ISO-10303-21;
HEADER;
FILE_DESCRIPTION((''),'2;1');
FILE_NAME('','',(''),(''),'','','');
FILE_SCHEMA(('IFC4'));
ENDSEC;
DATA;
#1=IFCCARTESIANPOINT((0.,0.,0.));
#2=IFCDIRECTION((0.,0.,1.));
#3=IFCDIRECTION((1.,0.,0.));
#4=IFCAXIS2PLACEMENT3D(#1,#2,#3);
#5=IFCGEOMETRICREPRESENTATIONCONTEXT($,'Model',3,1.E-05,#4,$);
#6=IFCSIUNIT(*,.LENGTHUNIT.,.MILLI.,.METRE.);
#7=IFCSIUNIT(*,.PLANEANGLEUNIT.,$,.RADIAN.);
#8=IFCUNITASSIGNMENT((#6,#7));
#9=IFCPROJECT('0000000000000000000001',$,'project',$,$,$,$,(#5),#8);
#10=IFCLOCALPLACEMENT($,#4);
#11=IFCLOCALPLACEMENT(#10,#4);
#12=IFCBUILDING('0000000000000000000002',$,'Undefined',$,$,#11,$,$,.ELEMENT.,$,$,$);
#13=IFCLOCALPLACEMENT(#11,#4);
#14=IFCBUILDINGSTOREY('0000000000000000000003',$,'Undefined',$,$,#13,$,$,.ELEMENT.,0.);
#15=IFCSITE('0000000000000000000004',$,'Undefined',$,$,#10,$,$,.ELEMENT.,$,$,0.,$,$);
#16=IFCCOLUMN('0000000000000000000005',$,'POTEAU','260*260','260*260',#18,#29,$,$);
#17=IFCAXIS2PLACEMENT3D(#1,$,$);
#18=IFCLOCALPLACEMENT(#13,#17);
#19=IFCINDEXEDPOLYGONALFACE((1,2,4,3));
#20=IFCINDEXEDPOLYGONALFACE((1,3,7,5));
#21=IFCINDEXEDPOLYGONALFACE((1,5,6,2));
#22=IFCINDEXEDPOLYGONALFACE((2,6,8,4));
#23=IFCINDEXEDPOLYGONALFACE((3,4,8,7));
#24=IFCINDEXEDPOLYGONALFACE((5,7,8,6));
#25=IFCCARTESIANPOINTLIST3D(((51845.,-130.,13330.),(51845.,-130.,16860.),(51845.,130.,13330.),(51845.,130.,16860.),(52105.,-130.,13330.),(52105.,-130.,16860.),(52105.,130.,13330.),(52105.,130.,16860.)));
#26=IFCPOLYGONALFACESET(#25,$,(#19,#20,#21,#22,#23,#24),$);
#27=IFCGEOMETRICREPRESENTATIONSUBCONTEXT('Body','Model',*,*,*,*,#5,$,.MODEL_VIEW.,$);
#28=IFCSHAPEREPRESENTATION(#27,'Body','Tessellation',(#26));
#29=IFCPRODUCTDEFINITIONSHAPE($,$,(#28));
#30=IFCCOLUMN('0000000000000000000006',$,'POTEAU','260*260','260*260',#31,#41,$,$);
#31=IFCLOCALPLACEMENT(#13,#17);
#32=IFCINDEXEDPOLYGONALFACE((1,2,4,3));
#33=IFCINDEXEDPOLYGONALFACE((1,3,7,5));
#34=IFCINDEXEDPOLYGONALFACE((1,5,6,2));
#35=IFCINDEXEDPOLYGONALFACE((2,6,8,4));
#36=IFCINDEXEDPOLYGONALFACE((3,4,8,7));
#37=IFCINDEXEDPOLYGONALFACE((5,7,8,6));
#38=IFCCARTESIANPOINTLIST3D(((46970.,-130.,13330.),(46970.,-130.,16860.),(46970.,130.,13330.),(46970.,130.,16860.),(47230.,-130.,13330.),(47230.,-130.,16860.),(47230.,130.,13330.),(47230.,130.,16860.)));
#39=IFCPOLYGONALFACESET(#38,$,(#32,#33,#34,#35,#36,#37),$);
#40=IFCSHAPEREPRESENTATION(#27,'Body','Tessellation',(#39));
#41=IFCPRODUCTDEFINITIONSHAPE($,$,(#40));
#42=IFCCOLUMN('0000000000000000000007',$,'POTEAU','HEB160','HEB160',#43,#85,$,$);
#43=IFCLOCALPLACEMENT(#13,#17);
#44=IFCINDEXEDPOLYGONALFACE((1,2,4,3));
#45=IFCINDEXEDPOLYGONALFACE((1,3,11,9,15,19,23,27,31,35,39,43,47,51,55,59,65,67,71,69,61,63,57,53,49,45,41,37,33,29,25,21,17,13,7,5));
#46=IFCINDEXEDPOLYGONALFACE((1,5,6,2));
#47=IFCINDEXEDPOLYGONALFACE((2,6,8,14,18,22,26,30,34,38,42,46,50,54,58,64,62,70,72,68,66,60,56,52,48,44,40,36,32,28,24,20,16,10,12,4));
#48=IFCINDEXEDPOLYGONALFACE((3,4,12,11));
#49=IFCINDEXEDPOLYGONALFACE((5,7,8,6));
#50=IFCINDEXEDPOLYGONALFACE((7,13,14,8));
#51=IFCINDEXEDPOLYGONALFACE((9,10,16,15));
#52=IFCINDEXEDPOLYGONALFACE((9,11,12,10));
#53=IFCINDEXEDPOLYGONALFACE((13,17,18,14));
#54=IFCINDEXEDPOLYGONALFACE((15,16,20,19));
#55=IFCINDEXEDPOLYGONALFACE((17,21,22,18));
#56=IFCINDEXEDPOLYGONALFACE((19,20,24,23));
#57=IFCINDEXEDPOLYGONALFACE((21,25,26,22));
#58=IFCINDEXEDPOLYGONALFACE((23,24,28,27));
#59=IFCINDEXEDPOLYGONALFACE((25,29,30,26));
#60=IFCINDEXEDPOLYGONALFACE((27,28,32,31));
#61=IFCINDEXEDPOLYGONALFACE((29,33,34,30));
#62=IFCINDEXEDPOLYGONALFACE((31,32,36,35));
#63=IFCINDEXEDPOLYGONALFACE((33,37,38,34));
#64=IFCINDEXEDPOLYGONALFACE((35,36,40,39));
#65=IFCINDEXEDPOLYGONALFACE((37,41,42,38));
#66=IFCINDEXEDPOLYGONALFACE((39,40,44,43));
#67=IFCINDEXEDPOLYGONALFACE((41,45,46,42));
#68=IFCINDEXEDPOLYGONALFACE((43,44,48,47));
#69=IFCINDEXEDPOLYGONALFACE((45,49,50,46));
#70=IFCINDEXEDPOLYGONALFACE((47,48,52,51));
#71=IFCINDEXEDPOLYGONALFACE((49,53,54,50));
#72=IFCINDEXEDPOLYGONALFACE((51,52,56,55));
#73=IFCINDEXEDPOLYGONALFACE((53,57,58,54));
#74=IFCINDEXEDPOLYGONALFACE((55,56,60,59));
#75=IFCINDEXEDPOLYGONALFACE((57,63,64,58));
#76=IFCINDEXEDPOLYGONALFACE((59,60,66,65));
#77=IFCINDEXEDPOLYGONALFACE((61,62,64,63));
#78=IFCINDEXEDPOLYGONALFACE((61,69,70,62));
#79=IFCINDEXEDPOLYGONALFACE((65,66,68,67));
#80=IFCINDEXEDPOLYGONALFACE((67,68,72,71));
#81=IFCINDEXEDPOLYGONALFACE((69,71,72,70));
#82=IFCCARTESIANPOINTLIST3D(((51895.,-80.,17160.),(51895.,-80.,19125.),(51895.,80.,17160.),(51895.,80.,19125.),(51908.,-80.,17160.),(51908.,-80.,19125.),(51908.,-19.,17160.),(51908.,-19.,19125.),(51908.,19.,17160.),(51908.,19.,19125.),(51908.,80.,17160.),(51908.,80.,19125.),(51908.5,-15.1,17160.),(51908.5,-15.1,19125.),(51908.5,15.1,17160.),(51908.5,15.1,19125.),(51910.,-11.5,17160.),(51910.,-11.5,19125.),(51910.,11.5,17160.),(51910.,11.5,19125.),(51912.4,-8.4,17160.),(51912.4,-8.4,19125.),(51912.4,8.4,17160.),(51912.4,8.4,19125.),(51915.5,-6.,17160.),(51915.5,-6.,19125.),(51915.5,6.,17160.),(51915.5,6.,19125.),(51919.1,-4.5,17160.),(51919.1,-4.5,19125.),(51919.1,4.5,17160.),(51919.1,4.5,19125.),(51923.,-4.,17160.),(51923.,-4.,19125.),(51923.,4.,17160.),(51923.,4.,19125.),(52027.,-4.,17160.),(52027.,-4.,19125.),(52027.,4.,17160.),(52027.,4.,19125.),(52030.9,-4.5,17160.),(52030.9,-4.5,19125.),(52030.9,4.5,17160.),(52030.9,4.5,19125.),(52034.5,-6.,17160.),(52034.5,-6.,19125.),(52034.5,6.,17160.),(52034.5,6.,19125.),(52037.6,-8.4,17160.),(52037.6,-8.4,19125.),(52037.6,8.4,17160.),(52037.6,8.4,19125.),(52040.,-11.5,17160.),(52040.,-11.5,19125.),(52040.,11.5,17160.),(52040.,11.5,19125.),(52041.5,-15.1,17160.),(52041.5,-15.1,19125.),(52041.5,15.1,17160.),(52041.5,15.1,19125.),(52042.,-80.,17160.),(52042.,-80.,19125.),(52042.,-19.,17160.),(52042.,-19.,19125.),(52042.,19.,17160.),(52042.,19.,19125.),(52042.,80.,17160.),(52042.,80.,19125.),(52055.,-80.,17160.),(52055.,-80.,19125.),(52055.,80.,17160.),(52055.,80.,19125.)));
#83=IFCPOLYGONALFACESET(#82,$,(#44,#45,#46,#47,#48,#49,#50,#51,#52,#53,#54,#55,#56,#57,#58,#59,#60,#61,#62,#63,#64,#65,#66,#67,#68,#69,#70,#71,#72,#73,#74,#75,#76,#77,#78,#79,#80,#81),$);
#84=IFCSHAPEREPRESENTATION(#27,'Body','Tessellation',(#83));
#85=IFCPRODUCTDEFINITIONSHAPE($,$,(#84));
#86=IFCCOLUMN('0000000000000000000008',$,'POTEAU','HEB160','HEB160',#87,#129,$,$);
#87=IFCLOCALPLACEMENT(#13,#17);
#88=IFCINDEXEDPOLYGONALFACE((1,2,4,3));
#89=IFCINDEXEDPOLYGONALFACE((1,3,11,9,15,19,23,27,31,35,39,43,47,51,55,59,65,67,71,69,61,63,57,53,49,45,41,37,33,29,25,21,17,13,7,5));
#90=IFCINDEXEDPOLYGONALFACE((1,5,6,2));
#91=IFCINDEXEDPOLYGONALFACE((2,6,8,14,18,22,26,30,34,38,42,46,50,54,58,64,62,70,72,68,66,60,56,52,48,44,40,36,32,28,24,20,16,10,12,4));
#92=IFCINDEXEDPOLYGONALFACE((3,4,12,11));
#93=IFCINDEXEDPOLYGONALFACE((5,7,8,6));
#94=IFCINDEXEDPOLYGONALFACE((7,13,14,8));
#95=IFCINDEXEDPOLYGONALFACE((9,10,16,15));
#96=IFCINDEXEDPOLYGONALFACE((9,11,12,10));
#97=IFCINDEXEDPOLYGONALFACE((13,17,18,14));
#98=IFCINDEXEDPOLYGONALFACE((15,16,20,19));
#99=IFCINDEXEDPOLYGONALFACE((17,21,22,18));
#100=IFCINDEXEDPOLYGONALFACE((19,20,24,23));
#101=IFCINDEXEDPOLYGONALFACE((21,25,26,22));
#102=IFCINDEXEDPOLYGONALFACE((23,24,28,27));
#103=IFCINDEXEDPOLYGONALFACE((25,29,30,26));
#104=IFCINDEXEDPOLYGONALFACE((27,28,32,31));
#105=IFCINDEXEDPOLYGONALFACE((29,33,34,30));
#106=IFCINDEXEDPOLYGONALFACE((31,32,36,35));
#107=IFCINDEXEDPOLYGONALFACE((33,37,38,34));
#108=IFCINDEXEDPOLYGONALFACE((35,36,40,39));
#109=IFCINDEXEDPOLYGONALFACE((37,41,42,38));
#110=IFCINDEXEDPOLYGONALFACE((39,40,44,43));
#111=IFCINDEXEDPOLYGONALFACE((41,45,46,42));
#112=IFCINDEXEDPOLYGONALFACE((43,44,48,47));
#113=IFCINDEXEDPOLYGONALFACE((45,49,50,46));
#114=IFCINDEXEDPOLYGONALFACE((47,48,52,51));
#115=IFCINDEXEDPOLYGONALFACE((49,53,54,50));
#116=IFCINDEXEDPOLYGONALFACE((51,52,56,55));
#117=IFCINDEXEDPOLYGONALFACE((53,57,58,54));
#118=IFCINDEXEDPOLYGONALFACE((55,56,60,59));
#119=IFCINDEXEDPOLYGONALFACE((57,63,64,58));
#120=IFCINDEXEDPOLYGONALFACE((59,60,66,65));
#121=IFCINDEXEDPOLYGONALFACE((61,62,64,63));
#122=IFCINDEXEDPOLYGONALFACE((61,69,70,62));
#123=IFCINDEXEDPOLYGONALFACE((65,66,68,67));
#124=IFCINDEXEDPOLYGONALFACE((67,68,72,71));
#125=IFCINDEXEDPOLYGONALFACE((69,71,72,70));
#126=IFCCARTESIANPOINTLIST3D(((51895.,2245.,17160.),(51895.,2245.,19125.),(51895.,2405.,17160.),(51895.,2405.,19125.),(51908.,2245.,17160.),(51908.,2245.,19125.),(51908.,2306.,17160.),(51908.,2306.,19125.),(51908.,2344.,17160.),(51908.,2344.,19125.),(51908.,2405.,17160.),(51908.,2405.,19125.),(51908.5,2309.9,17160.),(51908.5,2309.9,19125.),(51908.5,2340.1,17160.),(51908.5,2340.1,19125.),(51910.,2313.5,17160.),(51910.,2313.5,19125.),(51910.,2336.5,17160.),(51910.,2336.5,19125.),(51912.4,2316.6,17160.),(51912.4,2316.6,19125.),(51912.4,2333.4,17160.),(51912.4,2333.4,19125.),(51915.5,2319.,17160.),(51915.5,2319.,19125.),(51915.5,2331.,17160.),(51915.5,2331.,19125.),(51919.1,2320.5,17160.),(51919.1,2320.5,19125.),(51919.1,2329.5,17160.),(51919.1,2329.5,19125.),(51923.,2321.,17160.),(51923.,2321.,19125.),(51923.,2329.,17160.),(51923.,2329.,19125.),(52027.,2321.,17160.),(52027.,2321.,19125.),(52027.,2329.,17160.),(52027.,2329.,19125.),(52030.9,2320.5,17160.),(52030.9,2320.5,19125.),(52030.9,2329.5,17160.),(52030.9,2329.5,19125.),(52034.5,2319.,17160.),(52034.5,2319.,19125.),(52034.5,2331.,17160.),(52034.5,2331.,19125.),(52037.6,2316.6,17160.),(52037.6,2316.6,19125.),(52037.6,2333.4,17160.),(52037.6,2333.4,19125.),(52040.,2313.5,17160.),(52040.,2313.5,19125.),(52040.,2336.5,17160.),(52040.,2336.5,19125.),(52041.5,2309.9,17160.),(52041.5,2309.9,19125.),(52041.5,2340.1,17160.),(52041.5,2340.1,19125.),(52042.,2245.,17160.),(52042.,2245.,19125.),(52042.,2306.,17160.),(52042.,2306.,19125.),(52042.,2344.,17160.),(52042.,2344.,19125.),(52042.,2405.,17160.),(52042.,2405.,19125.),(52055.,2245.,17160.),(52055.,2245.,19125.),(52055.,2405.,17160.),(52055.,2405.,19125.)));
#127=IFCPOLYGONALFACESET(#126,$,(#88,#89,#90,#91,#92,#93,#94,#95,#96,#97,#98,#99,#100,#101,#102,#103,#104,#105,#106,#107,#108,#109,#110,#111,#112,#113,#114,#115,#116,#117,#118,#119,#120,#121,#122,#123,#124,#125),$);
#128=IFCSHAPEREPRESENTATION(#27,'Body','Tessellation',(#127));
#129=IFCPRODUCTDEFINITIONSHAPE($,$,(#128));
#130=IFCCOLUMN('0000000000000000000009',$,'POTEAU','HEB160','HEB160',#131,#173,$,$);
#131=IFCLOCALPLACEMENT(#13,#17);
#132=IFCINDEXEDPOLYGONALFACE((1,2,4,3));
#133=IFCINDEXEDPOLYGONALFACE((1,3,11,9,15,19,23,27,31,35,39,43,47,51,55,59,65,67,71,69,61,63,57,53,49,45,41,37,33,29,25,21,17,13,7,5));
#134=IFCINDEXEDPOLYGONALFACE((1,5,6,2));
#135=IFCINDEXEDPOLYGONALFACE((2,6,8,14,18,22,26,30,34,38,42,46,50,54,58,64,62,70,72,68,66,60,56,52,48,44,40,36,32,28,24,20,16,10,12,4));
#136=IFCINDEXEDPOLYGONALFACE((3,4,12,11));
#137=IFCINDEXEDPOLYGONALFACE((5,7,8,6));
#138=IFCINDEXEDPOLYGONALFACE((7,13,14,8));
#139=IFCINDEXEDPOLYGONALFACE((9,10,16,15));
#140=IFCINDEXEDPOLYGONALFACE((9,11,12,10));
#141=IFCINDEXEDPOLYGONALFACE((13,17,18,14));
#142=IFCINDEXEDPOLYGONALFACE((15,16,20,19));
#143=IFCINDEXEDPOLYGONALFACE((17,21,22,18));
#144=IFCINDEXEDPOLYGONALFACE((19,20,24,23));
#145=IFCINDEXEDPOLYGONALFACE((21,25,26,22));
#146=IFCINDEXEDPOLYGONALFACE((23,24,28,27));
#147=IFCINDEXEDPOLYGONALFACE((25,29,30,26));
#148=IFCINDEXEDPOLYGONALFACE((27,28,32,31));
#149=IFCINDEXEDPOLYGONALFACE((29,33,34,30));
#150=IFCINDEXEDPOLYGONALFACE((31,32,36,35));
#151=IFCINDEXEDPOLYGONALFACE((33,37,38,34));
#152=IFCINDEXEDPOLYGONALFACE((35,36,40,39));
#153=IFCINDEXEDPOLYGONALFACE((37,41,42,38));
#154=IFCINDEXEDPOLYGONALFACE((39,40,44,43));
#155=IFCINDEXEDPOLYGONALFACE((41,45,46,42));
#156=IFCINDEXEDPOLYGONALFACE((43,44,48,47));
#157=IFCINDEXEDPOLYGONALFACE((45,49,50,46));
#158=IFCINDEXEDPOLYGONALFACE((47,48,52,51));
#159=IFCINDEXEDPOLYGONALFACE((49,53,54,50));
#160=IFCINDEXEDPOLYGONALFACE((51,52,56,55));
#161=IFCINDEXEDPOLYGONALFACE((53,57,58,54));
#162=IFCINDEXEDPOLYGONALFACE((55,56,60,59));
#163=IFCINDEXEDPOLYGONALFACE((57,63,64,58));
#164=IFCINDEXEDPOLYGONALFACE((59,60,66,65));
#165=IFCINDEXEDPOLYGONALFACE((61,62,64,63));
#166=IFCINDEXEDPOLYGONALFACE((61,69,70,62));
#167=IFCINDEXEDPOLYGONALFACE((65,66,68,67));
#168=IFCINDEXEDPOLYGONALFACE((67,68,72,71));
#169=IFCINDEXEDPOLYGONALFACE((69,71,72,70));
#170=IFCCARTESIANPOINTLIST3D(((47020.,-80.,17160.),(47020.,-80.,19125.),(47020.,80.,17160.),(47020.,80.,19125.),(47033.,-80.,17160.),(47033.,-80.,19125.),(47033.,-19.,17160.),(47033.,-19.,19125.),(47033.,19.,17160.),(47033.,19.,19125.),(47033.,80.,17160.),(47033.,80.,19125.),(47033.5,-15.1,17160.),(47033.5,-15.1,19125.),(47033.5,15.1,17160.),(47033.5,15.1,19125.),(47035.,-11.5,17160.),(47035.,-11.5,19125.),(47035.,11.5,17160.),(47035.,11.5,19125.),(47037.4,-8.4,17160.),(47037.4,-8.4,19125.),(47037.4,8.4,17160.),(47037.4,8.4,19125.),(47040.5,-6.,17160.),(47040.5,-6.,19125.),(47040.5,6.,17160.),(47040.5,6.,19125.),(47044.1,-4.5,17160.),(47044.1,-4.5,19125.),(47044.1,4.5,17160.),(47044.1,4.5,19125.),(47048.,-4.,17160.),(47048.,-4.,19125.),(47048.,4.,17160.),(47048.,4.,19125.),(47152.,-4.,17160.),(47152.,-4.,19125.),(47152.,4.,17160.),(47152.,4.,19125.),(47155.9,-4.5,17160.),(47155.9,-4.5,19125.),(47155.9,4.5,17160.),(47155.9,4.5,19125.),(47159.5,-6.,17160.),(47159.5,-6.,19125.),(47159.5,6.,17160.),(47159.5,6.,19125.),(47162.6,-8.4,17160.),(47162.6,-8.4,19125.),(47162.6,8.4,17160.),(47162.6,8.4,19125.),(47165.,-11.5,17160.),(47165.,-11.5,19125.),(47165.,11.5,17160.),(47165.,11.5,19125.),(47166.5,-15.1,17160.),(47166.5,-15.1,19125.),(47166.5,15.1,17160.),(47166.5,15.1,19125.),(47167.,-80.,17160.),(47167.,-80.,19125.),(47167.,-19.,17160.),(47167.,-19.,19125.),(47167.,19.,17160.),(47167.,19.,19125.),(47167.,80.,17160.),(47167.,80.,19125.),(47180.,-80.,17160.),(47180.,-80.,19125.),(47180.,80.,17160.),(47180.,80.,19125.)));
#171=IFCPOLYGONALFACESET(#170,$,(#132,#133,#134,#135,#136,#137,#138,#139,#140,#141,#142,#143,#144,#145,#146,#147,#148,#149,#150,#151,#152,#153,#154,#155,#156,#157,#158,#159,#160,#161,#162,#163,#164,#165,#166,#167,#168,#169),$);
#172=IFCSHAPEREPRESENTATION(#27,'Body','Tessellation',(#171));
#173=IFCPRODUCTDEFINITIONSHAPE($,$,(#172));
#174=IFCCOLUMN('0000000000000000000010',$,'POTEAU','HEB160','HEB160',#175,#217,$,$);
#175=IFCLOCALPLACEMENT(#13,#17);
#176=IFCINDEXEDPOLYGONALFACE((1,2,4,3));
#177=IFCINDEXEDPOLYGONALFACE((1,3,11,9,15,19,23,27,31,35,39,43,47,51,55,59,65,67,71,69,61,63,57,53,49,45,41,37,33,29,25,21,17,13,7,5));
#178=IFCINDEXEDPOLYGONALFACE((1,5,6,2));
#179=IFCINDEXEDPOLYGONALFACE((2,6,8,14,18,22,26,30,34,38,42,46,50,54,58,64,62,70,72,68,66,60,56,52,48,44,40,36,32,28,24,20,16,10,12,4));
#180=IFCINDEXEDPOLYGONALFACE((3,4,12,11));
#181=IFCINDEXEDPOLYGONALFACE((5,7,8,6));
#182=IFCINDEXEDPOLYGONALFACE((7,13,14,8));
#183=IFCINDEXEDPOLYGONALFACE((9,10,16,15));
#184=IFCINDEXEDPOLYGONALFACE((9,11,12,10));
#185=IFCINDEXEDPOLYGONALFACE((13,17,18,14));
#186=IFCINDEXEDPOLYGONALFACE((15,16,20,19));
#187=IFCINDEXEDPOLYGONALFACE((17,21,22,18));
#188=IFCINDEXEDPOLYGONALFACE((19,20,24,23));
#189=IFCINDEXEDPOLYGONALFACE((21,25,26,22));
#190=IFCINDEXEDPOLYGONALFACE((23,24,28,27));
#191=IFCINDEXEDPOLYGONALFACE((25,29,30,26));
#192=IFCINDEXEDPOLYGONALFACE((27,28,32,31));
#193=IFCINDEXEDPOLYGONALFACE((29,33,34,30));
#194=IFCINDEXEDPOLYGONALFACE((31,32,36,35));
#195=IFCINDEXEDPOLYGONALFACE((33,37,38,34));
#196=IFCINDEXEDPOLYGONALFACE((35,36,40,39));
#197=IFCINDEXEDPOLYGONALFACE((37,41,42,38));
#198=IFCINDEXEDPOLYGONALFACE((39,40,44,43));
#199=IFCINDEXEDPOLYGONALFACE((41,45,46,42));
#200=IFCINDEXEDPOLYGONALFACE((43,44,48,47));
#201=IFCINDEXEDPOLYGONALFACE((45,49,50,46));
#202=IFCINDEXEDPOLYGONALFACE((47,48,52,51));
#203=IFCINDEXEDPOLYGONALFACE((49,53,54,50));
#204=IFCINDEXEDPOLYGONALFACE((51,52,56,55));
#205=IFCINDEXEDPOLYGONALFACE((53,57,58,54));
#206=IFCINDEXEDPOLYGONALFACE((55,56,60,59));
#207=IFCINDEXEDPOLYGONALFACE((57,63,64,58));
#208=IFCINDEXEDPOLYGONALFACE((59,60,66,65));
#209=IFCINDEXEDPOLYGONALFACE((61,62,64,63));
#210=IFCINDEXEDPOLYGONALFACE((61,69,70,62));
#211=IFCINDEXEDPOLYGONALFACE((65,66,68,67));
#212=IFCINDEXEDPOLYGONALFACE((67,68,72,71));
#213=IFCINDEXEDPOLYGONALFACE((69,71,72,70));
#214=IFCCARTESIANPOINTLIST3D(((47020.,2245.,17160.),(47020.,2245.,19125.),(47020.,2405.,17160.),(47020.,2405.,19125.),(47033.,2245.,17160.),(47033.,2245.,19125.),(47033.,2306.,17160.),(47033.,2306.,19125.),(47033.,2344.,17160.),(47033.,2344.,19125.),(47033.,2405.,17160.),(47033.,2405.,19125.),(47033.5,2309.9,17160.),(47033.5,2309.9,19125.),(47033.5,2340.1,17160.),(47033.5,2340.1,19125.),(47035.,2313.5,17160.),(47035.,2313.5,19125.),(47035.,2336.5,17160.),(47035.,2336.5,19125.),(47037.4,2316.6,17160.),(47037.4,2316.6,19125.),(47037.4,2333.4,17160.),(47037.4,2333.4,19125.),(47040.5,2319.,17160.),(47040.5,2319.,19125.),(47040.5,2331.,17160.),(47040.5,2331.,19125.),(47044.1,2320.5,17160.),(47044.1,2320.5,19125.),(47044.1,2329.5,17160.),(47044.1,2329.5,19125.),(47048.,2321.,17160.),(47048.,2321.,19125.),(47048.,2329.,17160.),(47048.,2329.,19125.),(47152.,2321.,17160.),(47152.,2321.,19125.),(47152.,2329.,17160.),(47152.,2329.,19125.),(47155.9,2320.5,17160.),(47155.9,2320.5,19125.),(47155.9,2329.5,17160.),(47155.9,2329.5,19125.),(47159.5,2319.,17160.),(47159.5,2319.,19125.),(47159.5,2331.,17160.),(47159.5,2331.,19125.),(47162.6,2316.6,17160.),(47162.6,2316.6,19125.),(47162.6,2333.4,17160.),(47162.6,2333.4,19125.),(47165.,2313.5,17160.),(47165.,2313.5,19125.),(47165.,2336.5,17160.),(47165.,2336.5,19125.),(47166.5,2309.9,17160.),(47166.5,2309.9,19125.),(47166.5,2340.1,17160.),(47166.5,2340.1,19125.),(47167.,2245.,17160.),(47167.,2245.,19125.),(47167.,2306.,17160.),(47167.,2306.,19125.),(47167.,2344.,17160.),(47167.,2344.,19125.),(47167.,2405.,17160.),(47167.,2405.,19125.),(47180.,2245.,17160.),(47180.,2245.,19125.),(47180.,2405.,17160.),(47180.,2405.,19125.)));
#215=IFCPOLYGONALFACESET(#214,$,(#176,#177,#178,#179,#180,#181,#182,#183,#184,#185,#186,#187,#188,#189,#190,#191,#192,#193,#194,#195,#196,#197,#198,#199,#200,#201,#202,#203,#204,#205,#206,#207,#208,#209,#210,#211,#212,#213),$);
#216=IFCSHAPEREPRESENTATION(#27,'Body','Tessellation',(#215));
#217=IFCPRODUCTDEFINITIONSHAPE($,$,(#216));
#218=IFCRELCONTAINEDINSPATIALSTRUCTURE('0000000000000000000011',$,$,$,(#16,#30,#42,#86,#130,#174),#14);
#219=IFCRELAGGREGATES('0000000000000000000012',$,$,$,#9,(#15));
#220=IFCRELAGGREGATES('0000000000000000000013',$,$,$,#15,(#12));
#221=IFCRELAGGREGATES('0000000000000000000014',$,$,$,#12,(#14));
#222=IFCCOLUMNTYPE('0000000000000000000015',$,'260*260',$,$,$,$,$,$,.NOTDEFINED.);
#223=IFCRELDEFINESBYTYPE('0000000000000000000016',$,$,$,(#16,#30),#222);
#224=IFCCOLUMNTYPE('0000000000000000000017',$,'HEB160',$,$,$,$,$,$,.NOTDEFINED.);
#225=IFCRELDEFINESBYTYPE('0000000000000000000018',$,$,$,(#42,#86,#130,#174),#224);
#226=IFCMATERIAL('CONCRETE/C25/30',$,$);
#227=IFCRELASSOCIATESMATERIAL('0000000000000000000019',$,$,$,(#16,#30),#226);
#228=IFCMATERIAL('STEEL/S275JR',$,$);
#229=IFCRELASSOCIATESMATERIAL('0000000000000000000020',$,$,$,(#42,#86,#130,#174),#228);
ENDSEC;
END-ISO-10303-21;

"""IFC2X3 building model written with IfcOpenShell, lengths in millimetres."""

from ifc_helpers import new_model, si_unit, frame, origin_with_axes, origin_2d_with_axis, place, context, subcontext, project, spatial, rectangle, i_section, extrude, material, type_object, element, save


model = new_model("IFC2X3")

# Units and contexts
model_context = context("Model", 3, precision=1e-05, world=origin_with_axes())
body_context = subcontext(model_context, "Body", "Model", "MODEL_VIEW")
ifc_project = project(units=[si_unit("LENGTHUNIT", "METRE", prefix="MILLI"), si_unit("PLANEANGLEUNIT", "RADIAN")], contexts=[model_context])

# Site, building, storey
site_placement = place(None, origin_with_axes())
site = spatial("IfcSite", under=ifc_project, at=site_placement, Name="Undefined", CompositionType="ELEMENT", RefElevation=0.0)
building_placement = place(site_placement, origin_with_axes())
building = spatial("IfcBuilding", under=site, at=building_placement, Name="Undefined", CompositionType="ELEMENT")
storey_placement = place(building_placement, origin_with_axes())
storey = spatial("IfcBuildingStorey", under=building, at=storey_placement, Name="Undefined", CompositionType="ELEMENT", Elevation=0.0)

# Columns
ifc_material_1 = material(Name="CONCRETE/C25/30")
column_type_1 = type_object("IfcColumnType", Name="260*260", PredefinedType="NOTDEFINED")
for number, where, z_axis, x_axis, name in (
    (1, (51975.0, 0.0, 13330.0), (0.0, 0.0, 1.0), (1.0, 0.0, 0.0), "POTEAU"),
    (2, (47100.0, 0.0, 13330.0), (0.0, 0.0, 1.0), (1.0, 0.0, 0.0), "POTEAU"),
):
    element("IfcColumn", number, at=place(storey_placement, frame(where, z_axis=z_axis, x_axis=x_axis)), inside=storey, type_object=column_type_1, material=ifc_material_1, Name=name, Description="260*260", ObjectType="260*260", context=body_context, shape_type="SweptSolid", body=[
        extrude(rectangle(XDim=260.0, YDim=260.0, at=origin_2d_with_axis()), frame((0.0, 0.0, 3530.0), z_axis=(0.0, 0.0, -1.0), x_axis=(-1.0, 0.0, 0.0)), (0.0, 0.0, 1.0), 3530.0),
    ])
ifc_material_2 = material(Name="STEEL/S275JR")
column_type_2 = type_object("IfcColumnType", Name="HEB160", PredefinedType="NOTDEFINED")
for number, where, z_axis, x_axis, name in (
    (3, (51975.0, 0.0, 17160.0), (0.0, 0.0, 1.0), (1.0, 0.0, 0.0), "POTEAU"),
    (4, (51975.0, 2325.0, 17160.0), (0.0, 0.0, 1.0), (1.0, 0.0, 0.0), "POTEAU"),
    (5, (47100.0, 0.0, 17160.0), (0.0, 0.0, 1.0), (1.0, 0.0, 0.0), "POTEAU"),
    (6, (47100.0, 2325.0, 17160.0), (0.0, 0.0, 1.0), (1.0, 0.0, 0.0), "POTEAU"),
):
    element("IfcColumn", number, at=place(storey_placement, frame(where, z_axis=z_axis, x_axis=x_axis)), inside=storey, type_object=column_type_2, material=ifc_material_2, Name=name, Description="HEB160", ObjectType="HEB160", context=body_context, shape_type="SweptSolid", body=[
        extrude(i_section(OverallWidth=160.0, OverallDepth=160.0, WebThickness=8.0, FlangeThickness=13.0, FilletRadius=15.0, at=origin_2d_with_axis()), frame((0.0, 0.0, 1965.0), z_axis=(0.0, 0.0, -1.0), x_axis=(0.0, -1.0, 0.0)), (0.0, 0.0, 1.0), 1965.0),
    ])

save(model, "model.ifc")
